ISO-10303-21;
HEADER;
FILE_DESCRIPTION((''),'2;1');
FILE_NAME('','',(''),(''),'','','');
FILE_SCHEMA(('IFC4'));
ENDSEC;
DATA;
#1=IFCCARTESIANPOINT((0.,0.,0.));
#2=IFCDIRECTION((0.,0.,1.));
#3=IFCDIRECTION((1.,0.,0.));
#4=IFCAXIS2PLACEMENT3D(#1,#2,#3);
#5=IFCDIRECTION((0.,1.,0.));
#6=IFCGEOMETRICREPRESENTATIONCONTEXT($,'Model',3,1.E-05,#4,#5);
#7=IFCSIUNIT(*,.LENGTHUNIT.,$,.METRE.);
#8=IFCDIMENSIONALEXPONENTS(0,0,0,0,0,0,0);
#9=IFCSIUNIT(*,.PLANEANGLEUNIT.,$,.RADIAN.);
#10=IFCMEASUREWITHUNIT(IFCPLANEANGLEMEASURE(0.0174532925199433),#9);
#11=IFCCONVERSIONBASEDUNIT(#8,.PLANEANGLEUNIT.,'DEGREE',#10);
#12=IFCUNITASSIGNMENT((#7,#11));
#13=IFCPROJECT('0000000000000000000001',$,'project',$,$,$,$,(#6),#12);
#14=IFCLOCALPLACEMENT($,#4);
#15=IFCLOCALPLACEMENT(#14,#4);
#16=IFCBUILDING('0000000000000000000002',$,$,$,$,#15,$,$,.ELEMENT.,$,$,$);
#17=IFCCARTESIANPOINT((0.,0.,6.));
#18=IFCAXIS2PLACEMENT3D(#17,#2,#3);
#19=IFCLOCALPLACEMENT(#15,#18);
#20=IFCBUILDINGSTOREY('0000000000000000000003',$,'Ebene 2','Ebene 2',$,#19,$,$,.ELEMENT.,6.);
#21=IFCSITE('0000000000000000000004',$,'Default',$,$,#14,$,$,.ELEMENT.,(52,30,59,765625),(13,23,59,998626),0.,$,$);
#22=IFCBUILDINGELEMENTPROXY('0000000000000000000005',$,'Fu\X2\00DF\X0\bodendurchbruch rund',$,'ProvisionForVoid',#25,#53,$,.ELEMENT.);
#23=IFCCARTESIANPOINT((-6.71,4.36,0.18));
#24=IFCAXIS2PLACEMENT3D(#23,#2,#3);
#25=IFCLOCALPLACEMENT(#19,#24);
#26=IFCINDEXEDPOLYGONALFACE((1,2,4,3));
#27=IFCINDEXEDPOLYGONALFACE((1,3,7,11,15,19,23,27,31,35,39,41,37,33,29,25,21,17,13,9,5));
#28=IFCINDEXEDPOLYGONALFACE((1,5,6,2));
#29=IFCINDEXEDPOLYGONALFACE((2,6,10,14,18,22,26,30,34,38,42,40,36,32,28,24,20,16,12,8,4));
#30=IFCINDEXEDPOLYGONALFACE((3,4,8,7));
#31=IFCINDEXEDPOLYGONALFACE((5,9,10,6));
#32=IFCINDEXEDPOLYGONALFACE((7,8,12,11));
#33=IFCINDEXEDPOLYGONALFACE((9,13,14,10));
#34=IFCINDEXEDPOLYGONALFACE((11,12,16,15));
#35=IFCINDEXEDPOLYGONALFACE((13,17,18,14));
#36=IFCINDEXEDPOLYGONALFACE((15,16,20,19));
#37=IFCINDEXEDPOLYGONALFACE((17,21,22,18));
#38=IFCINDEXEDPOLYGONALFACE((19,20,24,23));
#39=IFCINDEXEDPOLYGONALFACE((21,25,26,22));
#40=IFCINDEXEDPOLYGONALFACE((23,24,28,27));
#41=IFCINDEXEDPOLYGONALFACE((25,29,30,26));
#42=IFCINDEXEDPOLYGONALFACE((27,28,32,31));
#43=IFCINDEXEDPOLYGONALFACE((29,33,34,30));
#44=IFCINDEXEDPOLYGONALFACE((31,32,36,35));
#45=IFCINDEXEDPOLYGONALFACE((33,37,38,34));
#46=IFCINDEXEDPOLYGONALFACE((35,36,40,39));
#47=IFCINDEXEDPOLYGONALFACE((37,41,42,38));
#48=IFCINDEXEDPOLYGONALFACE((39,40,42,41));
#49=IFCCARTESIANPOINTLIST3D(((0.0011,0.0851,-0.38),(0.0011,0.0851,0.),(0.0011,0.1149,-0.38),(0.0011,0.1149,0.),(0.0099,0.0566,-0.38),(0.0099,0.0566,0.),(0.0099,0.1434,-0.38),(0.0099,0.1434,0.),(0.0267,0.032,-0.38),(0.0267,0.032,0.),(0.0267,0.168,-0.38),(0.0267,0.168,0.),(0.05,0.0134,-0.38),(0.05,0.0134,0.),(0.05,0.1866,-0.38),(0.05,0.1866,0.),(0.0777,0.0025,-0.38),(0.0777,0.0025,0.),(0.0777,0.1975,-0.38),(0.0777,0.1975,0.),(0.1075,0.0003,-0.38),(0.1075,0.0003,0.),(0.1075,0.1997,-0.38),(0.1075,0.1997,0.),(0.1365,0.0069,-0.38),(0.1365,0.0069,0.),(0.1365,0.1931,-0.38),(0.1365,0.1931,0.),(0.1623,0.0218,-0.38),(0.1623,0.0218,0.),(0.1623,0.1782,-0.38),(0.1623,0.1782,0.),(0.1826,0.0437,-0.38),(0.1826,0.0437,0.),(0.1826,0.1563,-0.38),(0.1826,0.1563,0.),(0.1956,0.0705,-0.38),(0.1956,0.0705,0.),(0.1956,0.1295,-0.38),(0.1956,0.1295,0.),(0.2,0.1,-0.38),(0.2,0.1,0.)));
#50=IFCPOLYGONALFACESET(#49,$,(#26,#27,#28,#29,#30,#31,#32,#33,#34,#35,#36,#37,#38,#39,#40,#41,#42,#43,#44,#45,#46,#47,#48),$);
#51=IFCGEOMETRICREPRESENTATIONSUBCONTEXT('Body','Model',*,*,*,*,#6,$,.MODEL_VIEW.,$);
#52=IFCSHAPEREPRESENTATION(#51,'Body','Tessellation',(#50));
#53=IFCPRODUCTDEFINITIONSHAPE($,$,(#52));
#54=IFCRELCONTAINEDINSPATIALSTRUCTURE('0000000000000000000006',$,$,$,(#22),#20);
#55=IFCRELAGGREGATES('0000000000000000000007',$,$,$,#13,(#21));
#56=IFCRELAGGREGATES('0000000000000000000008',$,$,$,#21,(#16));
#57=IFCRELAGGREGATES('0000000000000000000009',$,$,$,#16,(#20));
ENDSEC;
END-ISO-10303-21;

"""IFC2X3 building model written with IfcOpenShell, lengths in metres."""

from ifc_helpers import new_model, entity, si_unit, converted_unit, direction, frame, origin_with_axes, origin_2d_with_axis, place, context, subcontext, project, spatial, circle, extrude, source, transform, mapped, element, save


model = new_model("IFC2X3")

# Units and contexts
model_context = context("Model", 3, precision=1e-05, world=origin_with_axes(), true_north=direction((0.0, 1.0, 0.0)))
body_context = subcontext(model_context, "Body", "Model", "MODEL_VIEW")
ifc_project = project(units=[si_unit("LENGTHUNIT", "METRE"), converted_unit("PLANEANGLEUNIT", "DEGREE", entity("IfcPlaneAngleMeasure", 0.0174532925199433), si_unit("PLANEANGLEUNIT", "RADIAN"), dimensions=[0, 0, 0, 0, 0, 0, 0])], contexts=[model_context])

# Site, building, storey
site_placement = place(None, origin_with_axes())
site = spatial("IfcSite", under=ifc_project, at=site_placement, Name="Default", CompositionType="ELEMENT", RefLatitude=(52, 30, 59, 765625), RefLongitude=(13, 23, 59, 998626), RefElevation=0.0)
building_placement = place(site_placement, origin_with_axes())
building = spatial("IfcBuilding", under=site, at=building_placement, CompositionType="ELEMENT")
storey_placement = place(building_placement, frame((0.0, 0.0, 6.0), z_axis=(0.0, 0.0, 1.0), x_axis=(1.0, 0.0, 0.0)))
storey = spatial("IfcBuildingStorey", under=building, at=storey_placement, Name="Ebene 2", Description="Ebene 2", CompositionType="ELEMENT", Elevation=6.0)

# Building element proxy
shared_shape_1 = source(origin_with_axes(), body_context, "Body", "SweptSolid", [
    extrude(circle(Radius=0.1, at=origin_2d_with_axis()), frame((0.1, 0.1, 0.0), z_axis=(0.0, 0.0, 1.0), x_axis=(1.0, 0.0, 0.0)), (0.0, 0.0, -1.0), 0.38),
])
proxy_1_placement = place(storey_placement, frame((-6.71, 4.36, 0.18), z_axis=(0.0, 0.0, 1.0), x_axis=(1.0, 0.0, 0.0)))
element("IfcBuildingElementProxy", 1, at=proxy_1_placement, inside=storey, Name="Fußbodendurchbruch rund", ObjectType="ProvisionForVoid", CompositionType="ELEMENT", context=body_context, shape_type="MappedRepresentation", body=[
    mapped(shared_shape_1, transform((0.0, 0.0, 0.0), x_axis=(1.0, 0.0, 0.0), y_axis=(0.0, 1.0, 0.0), z_axis=(0.0, 0.0, 1.0), scale=1.0)),
])

save(model, "model.ifc")
